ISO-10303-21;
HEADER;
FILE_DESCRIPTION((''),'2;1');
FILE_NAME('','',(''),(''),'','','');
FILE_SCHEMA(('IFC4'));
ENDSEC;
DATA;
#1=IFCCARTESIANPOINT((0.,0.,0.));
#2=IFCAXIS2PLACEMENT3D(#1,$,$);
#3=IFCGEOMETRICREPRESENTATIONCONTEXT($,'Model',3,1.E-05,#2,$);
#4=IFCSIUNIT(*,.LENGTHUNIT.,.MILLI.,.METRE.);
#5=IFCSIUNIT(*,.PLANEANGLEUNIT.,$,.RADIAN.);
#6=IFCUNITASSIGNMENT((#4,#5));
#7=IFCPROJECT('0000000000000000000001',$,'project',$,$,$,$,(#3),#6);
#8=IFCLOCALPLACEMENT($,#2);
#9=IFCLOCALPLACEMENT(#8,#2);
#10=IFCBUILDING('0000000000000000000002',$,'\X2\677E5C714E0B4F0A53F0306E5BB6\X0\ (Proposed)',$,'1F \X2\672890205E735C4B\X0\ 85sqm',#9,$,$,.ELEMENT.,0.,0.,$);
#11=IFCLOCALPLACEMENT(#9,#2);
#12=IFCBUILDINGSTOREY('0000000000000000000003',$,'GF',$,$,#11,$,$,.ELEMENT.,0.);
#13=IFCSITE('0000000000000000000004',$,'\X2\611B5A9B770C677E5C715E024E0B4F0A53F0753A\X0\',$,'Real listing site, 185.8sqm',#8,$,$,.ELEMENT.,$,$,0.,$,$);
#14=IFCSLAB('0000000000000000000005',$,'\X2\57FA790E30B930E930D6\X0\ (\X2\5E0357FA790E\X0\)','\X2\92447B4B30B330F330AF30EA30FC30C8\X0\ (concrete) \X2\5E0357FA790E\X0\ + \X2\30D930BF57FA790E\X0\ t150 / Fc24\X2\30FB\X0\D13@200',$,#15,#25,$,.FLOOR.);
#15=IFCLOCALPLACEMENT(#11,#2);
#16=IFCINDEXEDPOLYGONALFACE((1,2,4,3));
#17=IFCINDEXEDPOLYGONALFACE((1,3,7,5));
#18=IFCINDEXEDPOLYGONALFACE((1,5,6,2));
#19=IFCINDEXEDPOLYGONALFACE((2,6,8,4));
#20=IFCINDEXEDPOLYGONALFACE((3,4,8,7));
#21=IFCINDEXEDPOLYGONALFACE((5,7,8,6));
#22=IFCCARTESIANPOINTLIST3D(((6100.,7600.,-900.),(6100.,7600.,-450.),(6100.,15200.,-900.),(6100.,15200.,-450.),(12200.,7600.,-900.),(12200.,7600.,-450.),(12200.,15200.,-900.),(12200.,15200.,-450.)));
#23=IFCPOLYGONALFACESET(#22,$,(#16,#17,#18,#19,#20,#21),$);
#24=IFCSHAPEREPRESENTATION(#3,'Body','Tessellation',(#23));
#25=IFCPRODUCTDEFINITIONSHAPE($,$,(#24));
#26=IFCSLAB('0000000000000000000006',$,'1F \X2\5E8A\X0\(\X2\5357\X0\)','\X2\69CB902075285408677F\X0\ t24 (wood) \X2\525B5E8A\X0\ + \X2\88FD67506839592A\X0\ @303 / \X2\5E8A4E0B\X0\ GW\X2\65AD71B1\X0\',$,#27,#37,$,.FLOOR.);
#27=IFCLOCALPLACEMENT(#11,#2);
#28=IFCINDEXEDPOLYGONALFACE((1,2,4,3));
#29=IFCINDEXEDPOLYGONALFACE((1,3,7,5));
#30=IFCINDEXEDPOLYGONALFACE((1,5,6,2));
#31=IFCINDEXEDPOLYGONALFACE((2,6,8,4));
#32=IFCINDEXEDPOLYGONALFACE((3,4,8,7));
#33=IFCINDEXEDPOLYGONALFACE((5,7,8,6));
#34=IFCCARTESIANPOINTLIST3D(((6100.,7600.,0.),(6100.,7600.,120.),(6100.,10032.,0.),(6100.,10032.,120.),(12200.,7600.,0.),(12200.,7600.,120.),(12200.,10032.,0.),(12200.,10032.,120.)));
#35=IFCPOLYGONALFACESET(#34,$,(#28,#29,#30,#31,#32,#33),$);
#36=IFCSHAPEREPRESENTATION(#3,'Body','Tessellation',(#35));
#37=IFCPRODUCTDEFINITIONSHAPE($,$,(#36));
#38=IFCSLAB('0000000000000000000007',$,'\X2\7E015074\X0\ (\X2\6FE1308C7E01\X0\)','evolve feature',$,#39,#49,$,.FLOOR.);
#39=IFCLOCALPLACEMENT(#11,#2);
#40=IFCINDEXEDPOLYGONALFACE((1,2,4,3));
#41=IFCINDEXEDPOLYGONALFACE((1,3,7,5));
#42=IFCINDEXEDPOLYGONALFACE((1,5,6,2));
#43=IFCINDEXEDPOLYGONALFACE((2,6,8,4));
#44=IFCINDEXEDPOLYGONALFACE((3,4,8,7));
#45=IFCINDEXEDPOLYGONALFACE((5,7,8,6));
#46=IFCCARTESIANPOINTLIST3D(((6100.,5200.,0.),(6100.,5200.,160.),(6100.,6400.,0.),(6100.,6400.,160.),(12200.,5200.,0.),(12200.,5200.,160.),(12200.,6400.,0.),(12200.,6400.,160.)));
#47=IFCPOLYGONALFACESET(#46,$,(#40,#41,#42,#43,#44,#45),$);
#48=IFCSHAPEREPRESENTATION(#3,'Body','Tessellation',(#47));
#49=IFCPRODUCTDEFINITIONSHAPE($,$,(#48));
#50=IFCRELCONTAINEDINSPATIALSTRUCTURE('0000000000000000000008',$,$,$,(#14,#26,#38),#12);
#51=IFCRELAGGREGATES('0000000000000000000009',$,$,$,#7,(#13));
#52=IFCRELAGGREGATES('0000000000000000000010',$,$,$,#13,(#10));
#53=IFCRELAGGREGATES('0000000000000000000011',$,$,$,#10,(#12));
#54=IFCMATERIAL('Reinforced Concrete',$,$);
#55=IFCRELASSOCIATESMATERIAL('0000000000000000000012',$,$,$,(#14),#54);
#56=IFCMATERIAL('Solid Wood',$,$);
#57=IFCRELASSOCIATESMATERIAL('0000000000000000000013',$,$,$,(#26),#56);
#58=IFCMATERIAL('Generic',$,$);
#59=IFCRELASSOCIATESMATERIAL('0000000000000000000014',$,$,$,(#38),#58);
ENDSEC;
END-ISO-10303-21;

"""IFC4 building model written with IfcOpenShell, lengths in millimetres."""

from ifc_helpers import new_model, si_unit, frame, frame_2d, origin, place, context, project, spatial, rectangle, extrude, material, element, save


model = new_model("IFC4")

# Units and contexts
model_context = context("Model", 3, precision=1e-05, world=origin())
ifc_project = project(units=[si_unit("LENGTHUNIT", "METRE", prefix="MILLI"), si_unit("PLANEANGLEUNIT", "RADIAN")], contexts=[model_context])

# Site, building, storey
site_placement = place(None, origin())
site = spatial("IfcSite", under=ifc_project, at=site_placement, Name="愛媛県松山市下伊台町", ObjectType="Real listing site, 185.8sqm", CompositionType="ELEMENT", RefElevation=0.0)
building_placement = place(site_placement, origin())
building = spatial("IfcBuilding", under=site, at=building_placement, Name="松山下伊台の家 (Proposed)", ObjectType="1F 木造平屋 85sqm", CompositionType="ELEMENT", ElevationOfRefHeight=0.0, ElevationOfTerrain=0.0)
storey_placement = place(building_placement, origin())
storey = spatial("IfcBuildingStorey", under=building, at=storey_placement, Name="GF", CompositionType="ELEMENT", Elevation=0.0)

# Slabs
ifc_material_1 = material(Name="Reinforced Concrete")
slab_1_placement = place(storey_placement, frame((3050.0, 3800.0, -450.0)))
element("IfcSlab", 1, at=slab_1_placement, inside=storey, material=ifc_material_1, Name="基礎スラブ (布基礎)", Description="鉄筋コンクリート (concrete) 布基礎 + ベタ基礎 t150 / Fc24・D13@200", PredefinedType="FLOOR", context=model_context, shape_type="SweptSolid", body=[
    extrude(rectangle(XDim=6100.0, YDim=7600.0, at=frame_2d((3050.0, 3800.0))), frame((3050.0, 3800.0, -450.0)), (0.0, 0.0, 1.0), 450.0),
])
ifc_material_2 = material(Name="Solid Wood")
slab_2_placement = place(storey_placement, frame((3050.0, 3800.0, 0.0)))
element("IfcSlab", 2, at=slab_2_placement, inside=storey, material=ifc_material_2, Name="1F 床(南)", Description="構造用合板 t24 (wood) 剛床 + 製材根太 @303 / 床下 GW断熱", PredefinedType="FLOOR", context=model_context, shape_type="SweptSolid", body=[
    extrude(rectangle(XDim=6100.0, YDim=2432.0, at=frame_2d((3050.0, 1216.0))), frame((3050.0, 3800.0, 0.0)), (0.0, 0.0, 1.0), 120.0),
])
ifc_material_3 = material(Name="Generic")
slab_3_placement = place(storey_placement, frame((3050.0, 2600.0, 0.0)))
element("IfcSlab", 3, at=slab_3_placement, inside=storey, material=ifc_material_3, Name="縁側 (濡れ縁)", Description="evolve feature", PredefinedType="FLOOR", context=model_context, shape_type="SweptSolid", body=[
    extrude(rectangle(XDim=6100.0, YDim=1200.0, at=frame_2d((3050.0, 600.0))), frame((3050.0, 2600.0, 0.0)), (0.0, 0.0, 1.0), 160.0),
])

save(model, "model.ifc")
